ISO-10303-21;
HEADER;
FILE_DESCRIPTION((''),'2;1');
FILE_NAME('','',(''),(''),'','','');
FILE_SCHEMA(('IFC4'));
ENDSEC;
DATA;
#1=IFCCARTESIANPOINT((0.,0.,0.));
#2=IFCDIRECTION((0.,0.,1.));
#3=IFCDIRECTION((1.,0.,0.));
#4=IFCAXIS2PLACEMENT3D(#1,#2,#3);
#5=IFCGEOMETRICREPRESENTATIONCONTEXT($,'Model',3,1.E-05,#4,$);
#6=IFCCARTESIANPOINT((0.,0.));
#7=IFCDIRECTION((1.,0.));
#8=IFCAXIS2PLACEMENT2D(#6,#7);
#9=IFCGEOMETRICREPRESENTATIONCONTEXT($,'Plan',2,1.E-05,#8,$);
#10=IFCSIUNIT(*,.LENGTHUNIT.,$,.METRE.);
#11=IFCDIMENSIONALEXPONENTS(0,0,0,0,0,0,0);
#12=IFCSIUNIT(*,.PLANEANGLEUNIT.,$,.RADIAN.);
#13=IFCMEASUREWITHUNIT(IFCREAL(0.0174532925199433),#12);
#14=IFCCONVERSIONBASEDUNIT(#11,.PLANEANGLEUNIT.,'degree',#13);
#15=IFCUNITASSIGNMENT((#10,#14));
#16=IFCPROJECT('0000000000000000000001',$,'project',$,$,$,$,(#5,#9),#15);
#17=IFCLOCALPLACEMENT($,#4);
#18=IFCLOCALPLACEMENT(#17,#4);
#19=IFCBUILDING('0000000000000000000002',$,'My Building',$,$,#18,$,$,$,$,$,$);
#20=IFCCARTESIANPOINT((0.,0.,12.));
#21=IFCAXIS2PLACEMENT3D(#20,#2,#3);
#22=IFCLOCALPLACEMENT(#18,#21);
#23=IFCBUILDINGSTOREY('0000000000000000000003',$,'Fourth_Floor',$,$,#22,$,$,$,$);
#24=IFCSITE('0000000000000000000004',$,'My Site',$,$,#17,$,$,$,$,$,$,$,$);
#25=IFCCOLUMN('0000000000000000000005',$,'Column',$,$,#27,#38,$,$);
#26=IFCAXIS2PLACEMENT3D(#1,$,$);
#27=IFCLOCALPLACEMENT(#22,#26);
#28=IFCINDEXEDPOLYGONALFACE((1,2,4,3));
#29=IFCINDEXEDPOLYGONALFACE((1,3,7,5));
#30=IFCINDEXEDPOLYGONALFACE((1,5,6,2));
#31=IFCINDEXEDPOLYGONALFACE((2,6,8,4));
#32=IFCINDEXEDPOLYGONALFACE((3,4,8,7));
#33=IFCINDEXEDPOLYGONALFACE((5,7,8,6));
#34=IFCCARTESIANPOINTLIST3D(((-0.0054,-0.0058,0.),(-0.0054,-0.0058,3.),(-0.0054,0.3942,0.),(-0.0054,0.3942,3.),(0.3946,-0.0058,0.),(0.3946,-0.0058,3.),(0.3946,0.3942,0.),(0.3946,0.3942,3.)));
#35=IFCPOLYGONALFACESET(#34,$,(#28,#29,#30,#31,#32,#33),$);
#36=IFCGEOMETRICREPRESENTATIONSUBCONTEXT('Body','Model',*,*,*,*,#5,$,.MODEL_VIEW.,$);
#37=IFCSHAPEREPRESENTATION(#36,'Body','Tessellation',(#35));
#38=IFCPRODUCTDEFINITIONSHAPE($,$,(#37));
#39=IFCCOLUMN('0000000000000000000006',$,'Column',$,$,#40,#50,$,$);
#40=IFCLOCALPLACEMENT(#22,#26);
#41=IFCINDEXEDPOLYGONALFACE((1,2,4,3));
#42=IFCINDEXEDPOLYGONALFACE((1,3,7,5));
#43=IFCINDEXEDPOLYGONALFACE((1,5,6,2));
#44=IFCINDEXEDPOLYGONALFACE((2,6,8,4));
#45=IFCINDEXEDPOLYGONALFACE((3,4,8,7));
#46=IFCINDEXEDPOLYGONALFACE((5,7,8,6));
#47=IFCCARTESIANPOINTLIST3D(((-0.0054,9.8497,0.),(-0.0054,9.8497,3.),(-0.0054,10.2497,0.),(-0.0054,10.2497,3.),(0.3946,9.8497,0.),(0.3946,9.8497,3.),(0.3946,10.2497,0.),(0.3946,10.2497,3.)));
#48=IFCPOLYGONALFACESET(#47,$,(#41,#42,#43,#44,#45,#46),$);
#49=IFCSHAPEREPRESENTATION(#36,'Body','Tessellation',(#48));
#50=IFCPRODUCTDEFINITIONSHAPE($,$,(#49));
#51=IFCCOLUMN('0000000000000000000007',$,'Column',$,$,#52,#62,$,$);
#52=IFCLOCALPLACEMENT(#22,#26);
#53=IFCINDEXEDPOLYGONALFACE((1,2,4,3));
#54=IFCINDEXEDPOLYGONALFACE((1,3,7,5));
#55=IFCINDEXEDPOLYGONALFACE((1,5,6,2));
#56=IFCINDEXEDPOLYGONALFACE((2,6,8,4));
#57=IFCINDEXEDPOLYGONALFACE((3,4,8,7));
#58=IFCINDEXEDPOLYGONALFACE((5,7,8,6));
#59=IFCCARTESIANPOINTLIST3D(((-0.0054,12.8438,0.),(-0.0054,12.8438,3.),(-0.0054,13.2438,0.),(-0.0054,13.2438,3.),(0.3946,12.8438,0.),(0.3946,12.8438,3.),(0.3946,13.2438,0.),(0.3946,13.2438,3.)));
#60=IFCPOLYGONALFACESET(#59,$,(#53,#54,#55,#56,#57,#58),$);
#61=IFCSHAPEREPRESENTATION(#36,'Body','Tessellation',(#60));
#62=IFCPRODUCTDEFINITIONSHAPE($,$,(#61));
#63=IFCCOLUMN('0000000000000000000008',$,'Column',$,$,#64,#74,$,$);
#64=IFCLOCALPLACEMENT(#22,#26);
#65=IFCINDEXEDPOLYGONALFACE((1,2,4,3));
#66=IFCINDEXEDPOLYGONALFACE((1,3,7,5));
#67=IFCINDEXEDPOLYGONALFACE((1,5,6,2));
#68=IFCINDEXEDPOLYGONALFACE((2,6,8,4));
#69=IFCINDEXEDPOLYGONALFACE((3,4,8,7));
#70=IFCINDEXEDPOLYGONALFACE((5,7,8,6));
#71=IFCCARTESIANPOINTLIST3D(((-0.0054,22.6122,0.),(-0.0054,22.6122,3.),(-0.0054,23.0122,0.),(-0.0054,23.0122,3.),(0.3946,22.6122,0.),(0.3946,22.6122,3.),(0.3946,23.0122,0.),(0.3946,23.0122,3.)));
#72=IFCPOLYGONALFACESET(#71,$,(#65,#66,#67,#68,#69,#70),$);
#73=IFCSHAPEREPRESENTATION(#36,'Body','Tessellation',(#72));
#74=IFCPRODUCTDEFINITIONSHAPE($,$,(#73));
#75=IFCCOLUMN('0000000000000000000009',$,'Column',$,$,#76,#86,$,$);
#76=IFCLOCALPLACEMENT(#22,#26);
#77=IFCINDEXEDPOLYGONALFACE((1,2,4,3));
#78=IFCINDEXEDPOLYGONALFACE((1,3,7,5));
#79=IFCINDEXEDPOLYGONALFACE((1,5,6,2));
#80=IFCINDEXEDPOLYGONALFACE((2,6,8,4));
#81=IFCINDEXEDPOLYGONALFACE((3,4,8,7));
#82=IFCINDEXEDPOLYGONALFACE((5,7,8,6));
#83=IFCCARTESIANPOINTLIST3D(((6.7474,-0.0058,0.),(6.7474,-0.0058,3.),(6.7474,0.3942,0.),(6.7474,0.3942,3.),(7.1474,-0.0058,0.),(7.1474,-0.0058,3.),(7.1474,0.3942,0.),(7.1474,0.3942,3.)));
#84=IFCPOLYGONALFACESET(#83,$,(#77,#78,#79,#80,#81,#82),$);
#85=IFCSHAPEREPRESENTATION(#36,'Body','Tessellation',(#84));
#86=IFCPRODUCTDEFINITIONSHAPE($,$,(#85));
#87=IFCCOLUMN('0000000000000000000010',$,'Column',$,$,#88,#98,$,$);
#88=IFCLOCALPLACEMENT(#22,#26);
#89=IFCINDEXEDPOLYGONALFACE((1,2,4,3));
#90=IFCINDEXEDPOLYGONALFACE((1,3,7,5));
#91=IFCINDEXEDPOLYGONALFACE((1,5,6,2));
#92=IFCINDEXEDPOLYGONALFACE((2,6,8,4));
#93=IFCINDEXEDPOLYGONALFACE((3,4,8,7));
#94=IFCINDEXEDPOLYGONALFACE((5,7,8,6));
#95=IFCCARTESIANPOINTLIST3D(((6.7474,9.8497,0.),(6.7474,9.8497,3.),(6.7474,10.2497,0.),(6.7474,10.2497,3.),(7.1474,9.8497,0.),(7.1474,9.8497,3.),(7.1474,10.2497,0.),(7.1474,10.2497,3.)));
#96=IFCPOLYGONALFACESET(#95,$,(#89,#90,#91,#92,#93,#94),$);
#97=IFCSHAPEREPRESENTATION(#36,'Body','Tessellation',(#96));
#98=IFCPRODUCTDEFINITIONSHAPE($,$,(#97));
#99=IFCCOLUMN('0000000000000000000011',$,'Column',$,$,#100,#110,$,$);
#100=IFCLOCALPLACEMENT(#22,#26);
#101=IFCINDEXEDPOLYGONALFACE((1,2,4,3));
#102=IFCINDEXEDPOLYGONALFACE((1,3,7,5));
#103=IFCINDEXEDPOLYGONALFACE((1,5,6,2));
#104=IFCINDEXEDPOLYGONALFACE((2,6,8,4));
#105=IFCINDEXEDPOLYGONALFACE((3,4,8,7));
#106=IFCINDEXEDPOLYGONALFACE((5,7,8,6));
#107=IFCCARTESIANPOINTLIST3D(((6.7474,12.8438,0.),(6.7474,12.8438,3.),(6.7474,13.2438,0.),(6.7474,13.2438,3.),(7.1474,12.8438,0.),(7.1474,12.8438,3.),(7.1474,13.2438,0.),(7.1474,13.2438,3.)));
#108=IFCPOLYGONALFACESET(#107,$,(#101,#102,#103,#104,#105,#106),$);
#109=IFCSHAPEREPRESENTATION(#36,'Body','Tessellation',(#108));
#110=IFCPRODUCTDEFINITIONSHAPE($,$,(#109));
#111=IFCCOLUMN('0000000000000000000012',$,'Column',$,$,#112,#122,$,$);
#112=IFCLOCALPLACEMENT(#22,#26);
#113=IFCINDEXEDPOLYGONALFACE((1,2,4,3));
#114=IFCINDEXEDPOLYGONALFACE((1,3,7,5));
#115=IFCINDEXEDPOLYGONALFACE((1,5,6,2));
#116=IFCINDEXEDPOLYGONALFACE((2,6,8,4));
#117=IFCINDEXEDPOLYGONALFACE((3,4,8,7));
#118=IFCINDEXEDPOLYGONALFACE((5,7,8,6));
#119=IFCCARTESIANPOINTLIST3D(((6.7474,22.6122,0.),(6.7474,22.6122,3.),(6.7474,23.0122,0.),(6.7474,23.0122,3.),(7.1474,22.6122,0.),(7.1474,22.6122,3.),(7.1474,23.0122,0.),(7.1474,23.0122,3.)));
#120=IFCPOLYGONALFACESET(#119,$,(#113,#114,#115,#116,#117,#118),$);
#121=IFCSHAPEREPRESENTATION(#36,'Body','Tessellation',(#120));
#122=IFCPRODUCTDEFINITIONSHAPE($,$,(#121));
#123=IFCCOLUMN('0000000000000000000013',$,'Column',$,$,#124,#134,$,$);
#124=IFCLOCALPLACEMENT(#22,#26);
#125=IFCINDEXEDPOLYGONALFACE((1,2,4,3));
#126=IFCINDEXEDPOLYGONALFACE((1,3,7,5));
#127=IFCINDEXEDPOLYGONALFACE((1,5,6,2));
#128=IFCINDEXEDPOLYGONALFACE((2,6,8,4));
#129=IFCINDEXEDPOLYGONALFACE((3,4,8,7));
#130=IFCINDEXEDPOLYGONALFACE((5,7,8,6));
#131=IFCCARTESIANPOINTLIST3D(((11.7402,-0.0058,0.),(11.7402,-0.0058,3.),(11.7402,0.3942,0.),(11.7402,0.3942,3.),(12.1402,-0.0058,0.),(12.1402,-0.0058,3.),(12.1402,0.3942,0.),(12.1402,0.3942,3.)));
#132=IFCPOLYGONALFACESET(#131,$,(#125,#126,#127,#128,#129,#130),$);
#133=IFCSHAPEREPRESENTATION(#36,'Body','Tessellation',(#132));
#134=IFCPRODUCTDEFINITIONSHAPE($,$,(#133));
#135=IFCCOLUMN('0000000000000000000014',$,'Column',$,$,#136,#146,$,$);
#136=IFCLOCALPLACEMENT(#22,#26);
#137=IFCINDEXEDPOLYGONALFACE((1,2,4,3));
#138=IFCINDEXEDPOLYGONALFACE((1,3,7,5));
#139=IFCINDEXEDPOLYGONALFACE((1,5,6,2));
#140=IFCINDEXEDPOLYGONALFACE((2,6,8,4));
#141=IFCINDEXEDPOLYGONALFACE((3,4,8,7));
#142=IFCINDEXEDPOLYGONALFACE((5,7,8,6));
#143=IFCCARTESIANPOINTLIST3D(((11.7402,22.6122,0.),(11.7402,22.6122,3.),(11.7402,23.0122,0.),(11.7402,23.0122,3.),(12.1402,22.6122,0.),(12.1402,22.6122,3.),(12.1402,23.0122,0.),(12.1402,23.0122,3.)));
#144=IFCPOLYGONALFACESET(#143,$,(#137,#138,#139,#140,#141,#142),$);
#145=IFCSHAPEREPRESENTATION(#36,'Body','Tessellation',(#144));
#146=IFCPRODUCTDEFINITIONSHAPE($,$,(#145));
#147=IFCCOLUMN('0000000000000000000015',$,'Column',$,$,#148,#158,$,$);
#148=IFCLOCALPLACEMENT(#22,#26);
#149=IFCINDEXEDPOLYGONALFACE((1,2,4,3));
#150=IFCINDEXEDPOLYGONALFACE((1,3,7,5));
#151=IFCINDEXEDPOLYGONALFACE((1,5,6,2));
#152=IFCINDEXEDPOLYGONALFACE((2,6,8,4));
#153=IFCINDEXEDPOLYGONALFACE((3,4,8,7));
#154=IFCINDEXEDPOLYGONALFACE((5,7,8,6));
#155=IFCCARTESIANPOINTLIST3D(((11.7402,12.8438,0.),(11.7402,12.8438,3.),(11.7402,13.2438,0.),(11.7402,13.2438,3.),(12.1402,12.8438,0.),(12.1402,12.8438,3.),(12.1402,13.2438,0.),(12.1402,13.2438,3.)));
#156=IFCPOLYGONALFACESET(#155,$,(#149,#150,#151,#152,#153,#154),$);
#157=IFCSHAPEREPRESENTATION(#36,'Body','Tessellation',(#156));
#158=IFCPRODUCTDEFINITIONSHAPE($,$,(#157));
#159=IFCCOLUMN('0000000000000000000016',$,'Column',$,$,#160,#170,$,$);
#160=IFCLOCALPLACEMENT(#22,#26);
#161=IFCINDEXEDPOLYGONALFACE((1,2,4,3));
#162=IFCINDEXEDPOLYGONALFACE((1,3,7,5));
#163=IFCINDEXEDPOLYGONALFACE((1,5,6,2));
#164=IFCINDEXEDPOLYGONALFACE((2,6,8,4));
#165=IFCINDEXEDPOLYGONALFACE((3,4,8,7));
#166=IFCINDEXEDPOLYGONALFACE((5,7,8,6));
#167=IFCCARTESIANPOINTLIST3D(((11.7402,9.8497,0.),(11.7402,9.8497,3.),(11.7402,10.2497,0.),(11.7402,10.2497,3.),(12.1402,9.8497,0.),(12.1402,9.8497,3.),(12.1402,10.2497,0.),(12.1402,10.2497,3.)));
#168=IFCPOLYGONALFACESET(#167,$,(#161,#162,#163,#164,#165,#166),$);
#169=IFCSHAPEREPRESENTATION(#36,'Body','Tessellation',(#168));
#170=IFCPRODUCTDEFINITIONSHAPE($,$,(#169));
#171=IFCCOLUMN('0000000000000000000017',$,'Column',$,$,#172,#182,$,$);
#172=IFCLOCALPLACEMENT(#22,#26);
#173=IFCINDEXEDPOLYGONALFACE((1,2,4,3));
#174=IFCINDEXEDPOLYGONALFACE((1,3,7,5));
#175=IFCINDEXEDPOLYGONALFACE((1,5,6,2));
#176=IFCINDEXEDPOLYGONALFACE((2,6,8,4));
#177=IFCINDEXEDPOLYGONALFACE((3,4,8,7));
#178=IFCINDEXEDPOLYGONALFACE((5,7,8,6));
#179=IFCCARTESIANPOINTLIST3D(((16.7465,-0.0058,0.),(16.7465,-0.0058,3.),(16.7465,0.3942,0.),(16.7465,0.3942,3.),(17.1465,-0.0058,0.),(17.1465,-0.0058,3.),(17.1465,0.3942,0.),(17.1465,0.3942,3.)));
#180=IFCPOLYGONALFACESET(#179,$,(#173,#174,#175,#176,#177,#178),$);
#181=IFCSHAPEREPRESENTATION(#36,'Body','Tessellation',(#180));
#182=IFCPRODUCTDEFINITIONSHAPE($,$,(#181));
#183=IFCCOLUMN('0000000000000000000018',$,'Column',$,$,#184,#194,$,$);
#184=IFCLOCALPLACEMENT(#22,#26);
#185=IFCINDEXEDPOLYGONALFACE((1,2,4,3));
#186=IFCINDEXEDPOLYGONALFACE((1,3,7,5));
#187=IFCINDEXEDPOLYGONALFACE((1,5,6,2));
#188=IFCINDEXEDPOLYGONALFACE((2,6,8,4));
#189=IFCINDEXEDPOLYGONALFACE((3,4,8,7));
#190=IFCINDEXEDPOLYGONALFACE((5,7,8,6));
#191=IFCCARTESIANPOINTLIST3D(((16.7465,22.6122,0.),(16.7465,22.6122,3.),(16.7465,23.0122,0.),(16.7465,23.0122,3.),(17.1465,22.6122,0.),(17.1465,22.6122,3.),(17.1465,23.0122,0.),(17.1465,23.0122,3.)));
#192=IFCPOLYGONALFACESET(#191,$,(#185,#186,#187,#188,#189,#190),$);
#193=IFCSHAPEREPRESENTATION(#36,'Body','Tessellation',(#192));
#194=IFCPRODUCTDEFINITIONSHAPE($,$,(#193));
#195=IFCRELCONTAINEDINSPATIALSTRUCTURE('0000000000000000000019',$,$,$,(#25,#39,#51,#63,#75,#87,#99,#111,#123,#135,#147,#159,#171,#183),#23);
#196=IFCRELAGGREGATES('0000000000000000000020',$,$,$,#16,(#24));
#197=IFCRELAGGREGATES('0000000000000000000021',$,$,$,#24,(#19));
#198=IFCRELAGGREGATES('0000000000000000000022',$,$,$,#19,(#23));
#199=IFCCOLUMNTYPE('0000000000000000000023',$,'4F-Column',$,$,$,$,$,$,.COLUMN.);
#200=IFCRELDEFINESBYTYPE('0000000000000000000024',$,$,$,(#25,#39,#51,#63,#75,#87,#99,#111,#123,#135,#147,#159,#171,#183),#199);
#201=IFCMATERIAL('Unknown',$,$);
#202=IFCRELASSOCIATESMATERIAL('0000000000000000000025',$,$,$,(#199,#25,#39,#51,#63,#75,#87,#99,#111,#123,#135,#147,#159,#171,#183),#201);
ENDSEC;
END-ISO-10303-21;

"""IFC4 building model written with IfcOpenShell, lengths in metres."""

from ifc_helpers import new_model, entity, si_unit, converted_unit, frame, origin_with_axes, origin_2d_with_axis, place, context, subcontext, project, spatial, rectangle, extrude, material, material_profile, profile_set, profile_usage, type_object, element, save


model = new_model("IFC4")

# Units and contexts
model_context = context("Model", 3, precision=1e-05, world=origin_with_axes())
plan_context = context("Plan", 2, precision=1e-05, world=origin_2d_with_axis())
body_context = subcontext(model_context, "Body", "Model", "MODEL_VIEW")
ifc_project = project(units=[si_unit("LENGTHUNIT", "METRE"), converted_unit("PLANEANGLEUNIT", "degree", entity("IfcReal", 0.0174532925199433), si_unit("PLANEANGLEUNIT", "RADIAN"), dimensions=[0, 0, 0, 0, 0, 0, 0])], contexts=[model_context, plan_context])

# Site, building, storey
site_placement = place(None, origin_with_axes())
site = spatial("IfcSite", under=ifc_project, at=site_placement, Name="My Site")
building_placement = place(site_placement, origin_with_axes())
building = spatial("IfcBuilding", under=site, at=building_placement, Name="My Building")
storey_placement = place(building_placement, frame((0.0, 0.0, 12.0), z_axis=(0.0, 0.0, 1.0), x_axis=(1.0, 0.0, 0.0)))
storey = spatial("IfcBuildingStorey", under=building, at=storey_placement, Name="Fourth_Floor")

# Columns
ifc_material = material(Name="Unknown")
ifc_material_profile_1 = material_profile(ifc_material, rectangle(XDim=0.4, YDim=0.4))
ifc_profile_set_1 = profile_set([ifc_material_profile_1])
ifc_profile_usage_1 = profile_usage(ifc_profile_set_1, cardinal=8)
column_type = type_object("IfcColumnType", Name="4F-Column", PredefinedType="COLUMN", material=ifc_profile_set_1)
column_1_placement = place(storey_placement, frame((0.1946, 0.3942, 0.0), z_axis=(0.0, 0.0, 1.0), x_axis=(1.0, 0.0, 0.0)))
element("IfcColumn", 1, at=column_1_placement, inside=storey, type_object=column_type, material=ifc_profile_usage_1, Name="Column", context=body_context, shape_type="SweptSolid", body=[
    extrude(rectangle(XDim=0.4, YDim=0.4), frame((0.0, -0.2, 0.0), z_axis=(0.0, 0.0, 1.0), x_axis=(1.0, 0.0, 0.0)), (0.0, 0.0, 1.0), 3.0),
])
ifc_profile_usage_2 = profile_usage(ifc_profile_set_1, cardinal=8)
column_2_placement = place(storey_placement, frame((0.1946, 10.2497, 0.0), z_axis=(0.0, 0.0, 1.0), x_axis=(1.0, 0.0, 0.0)))
element("IfcColumn", 2, at=column_2_placement, inside=storey, type_object=column_type, material=ifc_profile_usage_2, Name="Column", context=body_context, shape_type="SweptSolid", body=[
    extrude(rectangle(XDim=0.4, YDim=0.4), frame((0.0, -0.2, 0.0), z_axis=(0.0, 0.0, 1.0), x_axis=(1.0, 0.0, 0.0)), (0.0, 0.0, 1.0), 3.0),
])
ifc_profile_usage_3 = profile_usage(ifc_profile_set_1, cardinal=8)
column_3_placement = place(storey_placement, frame((0.1946, 13.2438, 0.0), z_axis=(0.0, 0.0, 1.0), x_axis=(1.0, 0.0, 0.0)))
element("IfcColumn", 3, at=column_3_placement, inside=storey, type_object=column_type, material=ifc_profile_usage_3, Name="Column", context=body_context, shape_type="SweptSolid", body=[
    extrude(rectangle(XDim=0.4, YDim=0.4), frame((0.0, -0.2, 0.0), z_axis=(0.0, 0.0, 1.0), x_axis=(1.0, 0.0, 0.0)), (0.0, 0.0, 1.0), 3.0),
])
ifc_profile_usage_4 = profile_usage(ifc_profile_set_1, cardinal=8)
column_4_placement = place(storey_placement, frame((0.1946, 23.0122, 0.0), z_axis=(0.0, 0.0, 1.0), x_axis=(1.0, 0.0, 0.0)))
element("IfcColumn", 4, at=column_4_placement, inside=storey, type_object=column_type, material=ifc_profile_usage_4, Name="Column", context=body_context, shape_type="SweptSolid", body=[
    extrude(rectangle(XDim=0.4, YDim=0.4), frame((0.0, -0.2, 0.0), z_axis=(0.0, 0.0, 1.0), x_axis=(1.0, 0.0, 0.0)), (0.0, 0.0, 1.0), 3.0),
])
ifc_profile_usage_5 = profile_usage(ifc_profile_set_1, cardinal=8)
column_5_placement = place(storey_placement, frame((6.9474, 0.3942, 0.0), z_axis=(0.0, 0.0, 1.0), x_axis=(1.0, 0.0, 0.0)))
element("IfcColumn", 5, at=column_5_placement, inside=storey, type_object=column_type, material=ifc_profile_usage_5, Name="Column", context=body_context, shape_type="SweptSolid", body=[
    extrude(rectangle(XDim=0.4, YDim=0.4), frame((0.0, -0.2, 0.0), z_axis=(0.0, 0.0, 1.0), x_axis=(1.0, 0.0, 0.0)), (0.0, 0.0, 1.0), 3.0),
])
ifc_profile_usage_6 = profile_usage(ifc_profile_set_1, cardinal=8)
column_6_placement = place(storey_placement, frame((6.9474, 10.2497, 0.0), z_axis=(0.0, 0.0, 1.0), x_axis=(1.0, 0.0, 0.0)))
element("IfcColumn", 6, at=column_6_placement, inside=storey, type_object=column_type, material=ifc_profile_usage_6, Name="Column", context=body_context, shape_type="SweptSolid", body=[
    extrude(rectangle(XDim=0.4, YDim=0.4), frame((0.0, -0.2, 0.0), z_axis=(0.0, 0.0, 1.0), x_axis=(1.0, 0.0, 0.0)), (0.0, 0.0, 1.0), 3.0),
])
ifc_profile_usage_7 = profile_usage(ifc_profile_set_1, cardinal=8)
column_7_placement = place(storey_placement, frame((6.9474, 13.2438, 0.0), z_axis=(0.0, 0.0, 1.0), x_axis=(1.0, 0.0, 0.0)))
element("IfcColumn", 7, at=column_7_placement, inside=storey, type_object=column_type, material=ifc_profile_usage_7, Name="Column", context=body_context, shape_type="SweptSolid", body=[
    extrude(rectangle(XDim=0.4, YDim=0.4), frame((0.0, -0.2, 0.0), z_axis=(0.0, 0.0, 1.0), x_axis=(1.0, 0.0, 0.0)), (0.0, 0.0, 1.0), 3.0),
])
ifc_profile_usage_8 = profile_usage(ifc_profile_set_1, cardinal=8)
column_8_placement = place(storey_placement, frame((6.9474, 23.0122, 0.0), z_axis=(0.0, 0.0, 1.0), x_axis=(1.0, 0.0, 0.0)))
element("IfcColumn", 8, at=column_8_placement, inside=storey, type_object=column_type, material=ifc_profile_usage_8, Name="Column", context=body_context, shape_type="SweptSolid", body=[
    extrude(rectangle(XDim=0.4, YDim=0.4), frame((0.0, -0.2, 0.0), z_axis=(0.0, 0.0, 1.0), x_axis=(1.0, 0.0, 0.0)), (0.0, 0.0, 1.0), 3.0),
])
ifc_profile_usage_9 = profile_usage(ifc_profile_set_1, cardinal=8)
column_9_placement = place(storey_placement, frame((11.9402, 0.3942, 0.0), z_axis=(0.0, 0.0, 1.0), x_axis=(1.0, 0.0, 0.0)))
element("IfcColumn", 9, at=column_9_placement, inside=storey, type_object=column_type, material=ifc_profile_usage_9, Name="Column", context=body_context, shape_type="SweptSolid", body=[
    extrude(rectangle(XDim=0.4, YDim=0.4), frame((0.0, -0.2, 0.0), z_axis=(0.0, 0.0, 1.0), x_axis=(1.0, 0.0, 0.0)), (0.0, 0.0, 1.0), 3.0),
])
ifc_profile_usage_10 = profile_usage(ifc_profile_set_1, cardinal=8)
column_10_placement = place(storey_placement, frame((11.9402, 23.0122, 0.0), z_axis=(0.0, 0.0, 1.0), x_axis=(1.0, 0.0, 0.0)))
element("IfcColumn", 10, at=column_10_placement, inside=storey, type_object=column_type, material=ifc_profile_usage_10, Name="Column", context=body_context, shape_type="SweptSolid", body=[
    extrude(rectangle(XDim=0.4, YDim=0.4), frame((0.0, -0.2, 0.0), z_axis=(0.0, 0.0, 1.0), x_axis=(1.0, 0.0, 0.0)), (0.0, 0.0, 1.0), 3.0),
])
ifc_profile_usage_11 = profile_usage(ifc_profile_set_1, cardinal=8)
column_11_placement = place(storey_placement, frame((11.9402, 13.2438, 0.0), z_axis=(0.0, 0.0, 1.0), x_axis=(1.0, 0.0, 0.0)))
element("IfcColumn", 11, at=column_11_placement, inside=storey, type_object=column_type, material=ifc_profile_usage_11, Name="Column", context=body_context, shape_type="SweptSolid", body=[
    extrude(rectangle(XDim=0.4, YDim=0.4), frame((0.0, -0.2, 0.0), z_axis=(0.0, 0.0, 1.0), x_axis=(1.0, 0.0, 0.0)), (0.0, 0.0, 1.0), 3.0),
])
ifc_profile_usage_12 = profile_usage(ifc_profile_set_1, cardinal=8)
column_12_placement = place(storey_placement, frame((11.9402, 10.2497, 0.0), z_axis=(0.0, 0.0, 1.0), x_axis=(1.0, 0.0, 0.0)))
element("IfcColumn", 12, at=column_12_placement, inside=storey, type_object=column_type, material=ifc_profile_usage_12, Name="Column", context=body_context, shape_type="SweptSolid", body=[
    extrude(rectangle(XDim=0.4, YDim=0.4), frame((0.0, -0.2, 0.0), z_axis=(0.0, 0.0, 1.0), x_axis=(1.0, 0.0, 0.0)), (0.0, 0.0, 1.0), 3.0),
])
ifc_profile_usage_13 = profile_usage(ifc_profile_set_1, cardinal=8)
column_13_placement = place(storey_placement, frame((16.9465, 0.3942, 0.0), z_axis=(0.0, 0.0, 1.0), x_axis=(1.0, 0.0, 0.0)))
element("IfcColumn", 13, at=column_13_placement, inside=storey, type_object=column_type, material=ifc_profile_usage_13, Name="Column", context=body_context, shape_type="SweptSolid", body=[
    extrude(rectangle(XDim=0.4, YDim=0.4), frame((0.0, -0.2, 0.0), z_axis=(0.0, 0.0, 1.0), x_axis=(1.0, 0.0, 0.0)), (0.0, 0.0, 1.0), 3.0),
])
ifc_profile_usage_14 = profile_usage(ifc_profile_set_1, cardinal=8)
column_14_placement = place(storey_placement, frame((16.9465, 23.0122, 0.0), z_axis=(0.0, 0.0, 1.0), x_axis=(1.0, 0.0, 0.0)))
element("IfcColumn", 14, at=column_14_placement, inside=storey, type_object=column_type, material=ifc_profile_usage_14, Name="Column", context=body_context, shape_type="SweptSolid", body=[
    extrude(rectangle(XDim=0.4, YDim=0.4), frame((0.0, -0.2, 0.0), z_axis=(0.0, 0.0, 1.0), x_axis=(1.0, 0.0, 0.0)), (0.0, 0.0, 1.0), 3.0),
])

save(model, "model.ifc")
